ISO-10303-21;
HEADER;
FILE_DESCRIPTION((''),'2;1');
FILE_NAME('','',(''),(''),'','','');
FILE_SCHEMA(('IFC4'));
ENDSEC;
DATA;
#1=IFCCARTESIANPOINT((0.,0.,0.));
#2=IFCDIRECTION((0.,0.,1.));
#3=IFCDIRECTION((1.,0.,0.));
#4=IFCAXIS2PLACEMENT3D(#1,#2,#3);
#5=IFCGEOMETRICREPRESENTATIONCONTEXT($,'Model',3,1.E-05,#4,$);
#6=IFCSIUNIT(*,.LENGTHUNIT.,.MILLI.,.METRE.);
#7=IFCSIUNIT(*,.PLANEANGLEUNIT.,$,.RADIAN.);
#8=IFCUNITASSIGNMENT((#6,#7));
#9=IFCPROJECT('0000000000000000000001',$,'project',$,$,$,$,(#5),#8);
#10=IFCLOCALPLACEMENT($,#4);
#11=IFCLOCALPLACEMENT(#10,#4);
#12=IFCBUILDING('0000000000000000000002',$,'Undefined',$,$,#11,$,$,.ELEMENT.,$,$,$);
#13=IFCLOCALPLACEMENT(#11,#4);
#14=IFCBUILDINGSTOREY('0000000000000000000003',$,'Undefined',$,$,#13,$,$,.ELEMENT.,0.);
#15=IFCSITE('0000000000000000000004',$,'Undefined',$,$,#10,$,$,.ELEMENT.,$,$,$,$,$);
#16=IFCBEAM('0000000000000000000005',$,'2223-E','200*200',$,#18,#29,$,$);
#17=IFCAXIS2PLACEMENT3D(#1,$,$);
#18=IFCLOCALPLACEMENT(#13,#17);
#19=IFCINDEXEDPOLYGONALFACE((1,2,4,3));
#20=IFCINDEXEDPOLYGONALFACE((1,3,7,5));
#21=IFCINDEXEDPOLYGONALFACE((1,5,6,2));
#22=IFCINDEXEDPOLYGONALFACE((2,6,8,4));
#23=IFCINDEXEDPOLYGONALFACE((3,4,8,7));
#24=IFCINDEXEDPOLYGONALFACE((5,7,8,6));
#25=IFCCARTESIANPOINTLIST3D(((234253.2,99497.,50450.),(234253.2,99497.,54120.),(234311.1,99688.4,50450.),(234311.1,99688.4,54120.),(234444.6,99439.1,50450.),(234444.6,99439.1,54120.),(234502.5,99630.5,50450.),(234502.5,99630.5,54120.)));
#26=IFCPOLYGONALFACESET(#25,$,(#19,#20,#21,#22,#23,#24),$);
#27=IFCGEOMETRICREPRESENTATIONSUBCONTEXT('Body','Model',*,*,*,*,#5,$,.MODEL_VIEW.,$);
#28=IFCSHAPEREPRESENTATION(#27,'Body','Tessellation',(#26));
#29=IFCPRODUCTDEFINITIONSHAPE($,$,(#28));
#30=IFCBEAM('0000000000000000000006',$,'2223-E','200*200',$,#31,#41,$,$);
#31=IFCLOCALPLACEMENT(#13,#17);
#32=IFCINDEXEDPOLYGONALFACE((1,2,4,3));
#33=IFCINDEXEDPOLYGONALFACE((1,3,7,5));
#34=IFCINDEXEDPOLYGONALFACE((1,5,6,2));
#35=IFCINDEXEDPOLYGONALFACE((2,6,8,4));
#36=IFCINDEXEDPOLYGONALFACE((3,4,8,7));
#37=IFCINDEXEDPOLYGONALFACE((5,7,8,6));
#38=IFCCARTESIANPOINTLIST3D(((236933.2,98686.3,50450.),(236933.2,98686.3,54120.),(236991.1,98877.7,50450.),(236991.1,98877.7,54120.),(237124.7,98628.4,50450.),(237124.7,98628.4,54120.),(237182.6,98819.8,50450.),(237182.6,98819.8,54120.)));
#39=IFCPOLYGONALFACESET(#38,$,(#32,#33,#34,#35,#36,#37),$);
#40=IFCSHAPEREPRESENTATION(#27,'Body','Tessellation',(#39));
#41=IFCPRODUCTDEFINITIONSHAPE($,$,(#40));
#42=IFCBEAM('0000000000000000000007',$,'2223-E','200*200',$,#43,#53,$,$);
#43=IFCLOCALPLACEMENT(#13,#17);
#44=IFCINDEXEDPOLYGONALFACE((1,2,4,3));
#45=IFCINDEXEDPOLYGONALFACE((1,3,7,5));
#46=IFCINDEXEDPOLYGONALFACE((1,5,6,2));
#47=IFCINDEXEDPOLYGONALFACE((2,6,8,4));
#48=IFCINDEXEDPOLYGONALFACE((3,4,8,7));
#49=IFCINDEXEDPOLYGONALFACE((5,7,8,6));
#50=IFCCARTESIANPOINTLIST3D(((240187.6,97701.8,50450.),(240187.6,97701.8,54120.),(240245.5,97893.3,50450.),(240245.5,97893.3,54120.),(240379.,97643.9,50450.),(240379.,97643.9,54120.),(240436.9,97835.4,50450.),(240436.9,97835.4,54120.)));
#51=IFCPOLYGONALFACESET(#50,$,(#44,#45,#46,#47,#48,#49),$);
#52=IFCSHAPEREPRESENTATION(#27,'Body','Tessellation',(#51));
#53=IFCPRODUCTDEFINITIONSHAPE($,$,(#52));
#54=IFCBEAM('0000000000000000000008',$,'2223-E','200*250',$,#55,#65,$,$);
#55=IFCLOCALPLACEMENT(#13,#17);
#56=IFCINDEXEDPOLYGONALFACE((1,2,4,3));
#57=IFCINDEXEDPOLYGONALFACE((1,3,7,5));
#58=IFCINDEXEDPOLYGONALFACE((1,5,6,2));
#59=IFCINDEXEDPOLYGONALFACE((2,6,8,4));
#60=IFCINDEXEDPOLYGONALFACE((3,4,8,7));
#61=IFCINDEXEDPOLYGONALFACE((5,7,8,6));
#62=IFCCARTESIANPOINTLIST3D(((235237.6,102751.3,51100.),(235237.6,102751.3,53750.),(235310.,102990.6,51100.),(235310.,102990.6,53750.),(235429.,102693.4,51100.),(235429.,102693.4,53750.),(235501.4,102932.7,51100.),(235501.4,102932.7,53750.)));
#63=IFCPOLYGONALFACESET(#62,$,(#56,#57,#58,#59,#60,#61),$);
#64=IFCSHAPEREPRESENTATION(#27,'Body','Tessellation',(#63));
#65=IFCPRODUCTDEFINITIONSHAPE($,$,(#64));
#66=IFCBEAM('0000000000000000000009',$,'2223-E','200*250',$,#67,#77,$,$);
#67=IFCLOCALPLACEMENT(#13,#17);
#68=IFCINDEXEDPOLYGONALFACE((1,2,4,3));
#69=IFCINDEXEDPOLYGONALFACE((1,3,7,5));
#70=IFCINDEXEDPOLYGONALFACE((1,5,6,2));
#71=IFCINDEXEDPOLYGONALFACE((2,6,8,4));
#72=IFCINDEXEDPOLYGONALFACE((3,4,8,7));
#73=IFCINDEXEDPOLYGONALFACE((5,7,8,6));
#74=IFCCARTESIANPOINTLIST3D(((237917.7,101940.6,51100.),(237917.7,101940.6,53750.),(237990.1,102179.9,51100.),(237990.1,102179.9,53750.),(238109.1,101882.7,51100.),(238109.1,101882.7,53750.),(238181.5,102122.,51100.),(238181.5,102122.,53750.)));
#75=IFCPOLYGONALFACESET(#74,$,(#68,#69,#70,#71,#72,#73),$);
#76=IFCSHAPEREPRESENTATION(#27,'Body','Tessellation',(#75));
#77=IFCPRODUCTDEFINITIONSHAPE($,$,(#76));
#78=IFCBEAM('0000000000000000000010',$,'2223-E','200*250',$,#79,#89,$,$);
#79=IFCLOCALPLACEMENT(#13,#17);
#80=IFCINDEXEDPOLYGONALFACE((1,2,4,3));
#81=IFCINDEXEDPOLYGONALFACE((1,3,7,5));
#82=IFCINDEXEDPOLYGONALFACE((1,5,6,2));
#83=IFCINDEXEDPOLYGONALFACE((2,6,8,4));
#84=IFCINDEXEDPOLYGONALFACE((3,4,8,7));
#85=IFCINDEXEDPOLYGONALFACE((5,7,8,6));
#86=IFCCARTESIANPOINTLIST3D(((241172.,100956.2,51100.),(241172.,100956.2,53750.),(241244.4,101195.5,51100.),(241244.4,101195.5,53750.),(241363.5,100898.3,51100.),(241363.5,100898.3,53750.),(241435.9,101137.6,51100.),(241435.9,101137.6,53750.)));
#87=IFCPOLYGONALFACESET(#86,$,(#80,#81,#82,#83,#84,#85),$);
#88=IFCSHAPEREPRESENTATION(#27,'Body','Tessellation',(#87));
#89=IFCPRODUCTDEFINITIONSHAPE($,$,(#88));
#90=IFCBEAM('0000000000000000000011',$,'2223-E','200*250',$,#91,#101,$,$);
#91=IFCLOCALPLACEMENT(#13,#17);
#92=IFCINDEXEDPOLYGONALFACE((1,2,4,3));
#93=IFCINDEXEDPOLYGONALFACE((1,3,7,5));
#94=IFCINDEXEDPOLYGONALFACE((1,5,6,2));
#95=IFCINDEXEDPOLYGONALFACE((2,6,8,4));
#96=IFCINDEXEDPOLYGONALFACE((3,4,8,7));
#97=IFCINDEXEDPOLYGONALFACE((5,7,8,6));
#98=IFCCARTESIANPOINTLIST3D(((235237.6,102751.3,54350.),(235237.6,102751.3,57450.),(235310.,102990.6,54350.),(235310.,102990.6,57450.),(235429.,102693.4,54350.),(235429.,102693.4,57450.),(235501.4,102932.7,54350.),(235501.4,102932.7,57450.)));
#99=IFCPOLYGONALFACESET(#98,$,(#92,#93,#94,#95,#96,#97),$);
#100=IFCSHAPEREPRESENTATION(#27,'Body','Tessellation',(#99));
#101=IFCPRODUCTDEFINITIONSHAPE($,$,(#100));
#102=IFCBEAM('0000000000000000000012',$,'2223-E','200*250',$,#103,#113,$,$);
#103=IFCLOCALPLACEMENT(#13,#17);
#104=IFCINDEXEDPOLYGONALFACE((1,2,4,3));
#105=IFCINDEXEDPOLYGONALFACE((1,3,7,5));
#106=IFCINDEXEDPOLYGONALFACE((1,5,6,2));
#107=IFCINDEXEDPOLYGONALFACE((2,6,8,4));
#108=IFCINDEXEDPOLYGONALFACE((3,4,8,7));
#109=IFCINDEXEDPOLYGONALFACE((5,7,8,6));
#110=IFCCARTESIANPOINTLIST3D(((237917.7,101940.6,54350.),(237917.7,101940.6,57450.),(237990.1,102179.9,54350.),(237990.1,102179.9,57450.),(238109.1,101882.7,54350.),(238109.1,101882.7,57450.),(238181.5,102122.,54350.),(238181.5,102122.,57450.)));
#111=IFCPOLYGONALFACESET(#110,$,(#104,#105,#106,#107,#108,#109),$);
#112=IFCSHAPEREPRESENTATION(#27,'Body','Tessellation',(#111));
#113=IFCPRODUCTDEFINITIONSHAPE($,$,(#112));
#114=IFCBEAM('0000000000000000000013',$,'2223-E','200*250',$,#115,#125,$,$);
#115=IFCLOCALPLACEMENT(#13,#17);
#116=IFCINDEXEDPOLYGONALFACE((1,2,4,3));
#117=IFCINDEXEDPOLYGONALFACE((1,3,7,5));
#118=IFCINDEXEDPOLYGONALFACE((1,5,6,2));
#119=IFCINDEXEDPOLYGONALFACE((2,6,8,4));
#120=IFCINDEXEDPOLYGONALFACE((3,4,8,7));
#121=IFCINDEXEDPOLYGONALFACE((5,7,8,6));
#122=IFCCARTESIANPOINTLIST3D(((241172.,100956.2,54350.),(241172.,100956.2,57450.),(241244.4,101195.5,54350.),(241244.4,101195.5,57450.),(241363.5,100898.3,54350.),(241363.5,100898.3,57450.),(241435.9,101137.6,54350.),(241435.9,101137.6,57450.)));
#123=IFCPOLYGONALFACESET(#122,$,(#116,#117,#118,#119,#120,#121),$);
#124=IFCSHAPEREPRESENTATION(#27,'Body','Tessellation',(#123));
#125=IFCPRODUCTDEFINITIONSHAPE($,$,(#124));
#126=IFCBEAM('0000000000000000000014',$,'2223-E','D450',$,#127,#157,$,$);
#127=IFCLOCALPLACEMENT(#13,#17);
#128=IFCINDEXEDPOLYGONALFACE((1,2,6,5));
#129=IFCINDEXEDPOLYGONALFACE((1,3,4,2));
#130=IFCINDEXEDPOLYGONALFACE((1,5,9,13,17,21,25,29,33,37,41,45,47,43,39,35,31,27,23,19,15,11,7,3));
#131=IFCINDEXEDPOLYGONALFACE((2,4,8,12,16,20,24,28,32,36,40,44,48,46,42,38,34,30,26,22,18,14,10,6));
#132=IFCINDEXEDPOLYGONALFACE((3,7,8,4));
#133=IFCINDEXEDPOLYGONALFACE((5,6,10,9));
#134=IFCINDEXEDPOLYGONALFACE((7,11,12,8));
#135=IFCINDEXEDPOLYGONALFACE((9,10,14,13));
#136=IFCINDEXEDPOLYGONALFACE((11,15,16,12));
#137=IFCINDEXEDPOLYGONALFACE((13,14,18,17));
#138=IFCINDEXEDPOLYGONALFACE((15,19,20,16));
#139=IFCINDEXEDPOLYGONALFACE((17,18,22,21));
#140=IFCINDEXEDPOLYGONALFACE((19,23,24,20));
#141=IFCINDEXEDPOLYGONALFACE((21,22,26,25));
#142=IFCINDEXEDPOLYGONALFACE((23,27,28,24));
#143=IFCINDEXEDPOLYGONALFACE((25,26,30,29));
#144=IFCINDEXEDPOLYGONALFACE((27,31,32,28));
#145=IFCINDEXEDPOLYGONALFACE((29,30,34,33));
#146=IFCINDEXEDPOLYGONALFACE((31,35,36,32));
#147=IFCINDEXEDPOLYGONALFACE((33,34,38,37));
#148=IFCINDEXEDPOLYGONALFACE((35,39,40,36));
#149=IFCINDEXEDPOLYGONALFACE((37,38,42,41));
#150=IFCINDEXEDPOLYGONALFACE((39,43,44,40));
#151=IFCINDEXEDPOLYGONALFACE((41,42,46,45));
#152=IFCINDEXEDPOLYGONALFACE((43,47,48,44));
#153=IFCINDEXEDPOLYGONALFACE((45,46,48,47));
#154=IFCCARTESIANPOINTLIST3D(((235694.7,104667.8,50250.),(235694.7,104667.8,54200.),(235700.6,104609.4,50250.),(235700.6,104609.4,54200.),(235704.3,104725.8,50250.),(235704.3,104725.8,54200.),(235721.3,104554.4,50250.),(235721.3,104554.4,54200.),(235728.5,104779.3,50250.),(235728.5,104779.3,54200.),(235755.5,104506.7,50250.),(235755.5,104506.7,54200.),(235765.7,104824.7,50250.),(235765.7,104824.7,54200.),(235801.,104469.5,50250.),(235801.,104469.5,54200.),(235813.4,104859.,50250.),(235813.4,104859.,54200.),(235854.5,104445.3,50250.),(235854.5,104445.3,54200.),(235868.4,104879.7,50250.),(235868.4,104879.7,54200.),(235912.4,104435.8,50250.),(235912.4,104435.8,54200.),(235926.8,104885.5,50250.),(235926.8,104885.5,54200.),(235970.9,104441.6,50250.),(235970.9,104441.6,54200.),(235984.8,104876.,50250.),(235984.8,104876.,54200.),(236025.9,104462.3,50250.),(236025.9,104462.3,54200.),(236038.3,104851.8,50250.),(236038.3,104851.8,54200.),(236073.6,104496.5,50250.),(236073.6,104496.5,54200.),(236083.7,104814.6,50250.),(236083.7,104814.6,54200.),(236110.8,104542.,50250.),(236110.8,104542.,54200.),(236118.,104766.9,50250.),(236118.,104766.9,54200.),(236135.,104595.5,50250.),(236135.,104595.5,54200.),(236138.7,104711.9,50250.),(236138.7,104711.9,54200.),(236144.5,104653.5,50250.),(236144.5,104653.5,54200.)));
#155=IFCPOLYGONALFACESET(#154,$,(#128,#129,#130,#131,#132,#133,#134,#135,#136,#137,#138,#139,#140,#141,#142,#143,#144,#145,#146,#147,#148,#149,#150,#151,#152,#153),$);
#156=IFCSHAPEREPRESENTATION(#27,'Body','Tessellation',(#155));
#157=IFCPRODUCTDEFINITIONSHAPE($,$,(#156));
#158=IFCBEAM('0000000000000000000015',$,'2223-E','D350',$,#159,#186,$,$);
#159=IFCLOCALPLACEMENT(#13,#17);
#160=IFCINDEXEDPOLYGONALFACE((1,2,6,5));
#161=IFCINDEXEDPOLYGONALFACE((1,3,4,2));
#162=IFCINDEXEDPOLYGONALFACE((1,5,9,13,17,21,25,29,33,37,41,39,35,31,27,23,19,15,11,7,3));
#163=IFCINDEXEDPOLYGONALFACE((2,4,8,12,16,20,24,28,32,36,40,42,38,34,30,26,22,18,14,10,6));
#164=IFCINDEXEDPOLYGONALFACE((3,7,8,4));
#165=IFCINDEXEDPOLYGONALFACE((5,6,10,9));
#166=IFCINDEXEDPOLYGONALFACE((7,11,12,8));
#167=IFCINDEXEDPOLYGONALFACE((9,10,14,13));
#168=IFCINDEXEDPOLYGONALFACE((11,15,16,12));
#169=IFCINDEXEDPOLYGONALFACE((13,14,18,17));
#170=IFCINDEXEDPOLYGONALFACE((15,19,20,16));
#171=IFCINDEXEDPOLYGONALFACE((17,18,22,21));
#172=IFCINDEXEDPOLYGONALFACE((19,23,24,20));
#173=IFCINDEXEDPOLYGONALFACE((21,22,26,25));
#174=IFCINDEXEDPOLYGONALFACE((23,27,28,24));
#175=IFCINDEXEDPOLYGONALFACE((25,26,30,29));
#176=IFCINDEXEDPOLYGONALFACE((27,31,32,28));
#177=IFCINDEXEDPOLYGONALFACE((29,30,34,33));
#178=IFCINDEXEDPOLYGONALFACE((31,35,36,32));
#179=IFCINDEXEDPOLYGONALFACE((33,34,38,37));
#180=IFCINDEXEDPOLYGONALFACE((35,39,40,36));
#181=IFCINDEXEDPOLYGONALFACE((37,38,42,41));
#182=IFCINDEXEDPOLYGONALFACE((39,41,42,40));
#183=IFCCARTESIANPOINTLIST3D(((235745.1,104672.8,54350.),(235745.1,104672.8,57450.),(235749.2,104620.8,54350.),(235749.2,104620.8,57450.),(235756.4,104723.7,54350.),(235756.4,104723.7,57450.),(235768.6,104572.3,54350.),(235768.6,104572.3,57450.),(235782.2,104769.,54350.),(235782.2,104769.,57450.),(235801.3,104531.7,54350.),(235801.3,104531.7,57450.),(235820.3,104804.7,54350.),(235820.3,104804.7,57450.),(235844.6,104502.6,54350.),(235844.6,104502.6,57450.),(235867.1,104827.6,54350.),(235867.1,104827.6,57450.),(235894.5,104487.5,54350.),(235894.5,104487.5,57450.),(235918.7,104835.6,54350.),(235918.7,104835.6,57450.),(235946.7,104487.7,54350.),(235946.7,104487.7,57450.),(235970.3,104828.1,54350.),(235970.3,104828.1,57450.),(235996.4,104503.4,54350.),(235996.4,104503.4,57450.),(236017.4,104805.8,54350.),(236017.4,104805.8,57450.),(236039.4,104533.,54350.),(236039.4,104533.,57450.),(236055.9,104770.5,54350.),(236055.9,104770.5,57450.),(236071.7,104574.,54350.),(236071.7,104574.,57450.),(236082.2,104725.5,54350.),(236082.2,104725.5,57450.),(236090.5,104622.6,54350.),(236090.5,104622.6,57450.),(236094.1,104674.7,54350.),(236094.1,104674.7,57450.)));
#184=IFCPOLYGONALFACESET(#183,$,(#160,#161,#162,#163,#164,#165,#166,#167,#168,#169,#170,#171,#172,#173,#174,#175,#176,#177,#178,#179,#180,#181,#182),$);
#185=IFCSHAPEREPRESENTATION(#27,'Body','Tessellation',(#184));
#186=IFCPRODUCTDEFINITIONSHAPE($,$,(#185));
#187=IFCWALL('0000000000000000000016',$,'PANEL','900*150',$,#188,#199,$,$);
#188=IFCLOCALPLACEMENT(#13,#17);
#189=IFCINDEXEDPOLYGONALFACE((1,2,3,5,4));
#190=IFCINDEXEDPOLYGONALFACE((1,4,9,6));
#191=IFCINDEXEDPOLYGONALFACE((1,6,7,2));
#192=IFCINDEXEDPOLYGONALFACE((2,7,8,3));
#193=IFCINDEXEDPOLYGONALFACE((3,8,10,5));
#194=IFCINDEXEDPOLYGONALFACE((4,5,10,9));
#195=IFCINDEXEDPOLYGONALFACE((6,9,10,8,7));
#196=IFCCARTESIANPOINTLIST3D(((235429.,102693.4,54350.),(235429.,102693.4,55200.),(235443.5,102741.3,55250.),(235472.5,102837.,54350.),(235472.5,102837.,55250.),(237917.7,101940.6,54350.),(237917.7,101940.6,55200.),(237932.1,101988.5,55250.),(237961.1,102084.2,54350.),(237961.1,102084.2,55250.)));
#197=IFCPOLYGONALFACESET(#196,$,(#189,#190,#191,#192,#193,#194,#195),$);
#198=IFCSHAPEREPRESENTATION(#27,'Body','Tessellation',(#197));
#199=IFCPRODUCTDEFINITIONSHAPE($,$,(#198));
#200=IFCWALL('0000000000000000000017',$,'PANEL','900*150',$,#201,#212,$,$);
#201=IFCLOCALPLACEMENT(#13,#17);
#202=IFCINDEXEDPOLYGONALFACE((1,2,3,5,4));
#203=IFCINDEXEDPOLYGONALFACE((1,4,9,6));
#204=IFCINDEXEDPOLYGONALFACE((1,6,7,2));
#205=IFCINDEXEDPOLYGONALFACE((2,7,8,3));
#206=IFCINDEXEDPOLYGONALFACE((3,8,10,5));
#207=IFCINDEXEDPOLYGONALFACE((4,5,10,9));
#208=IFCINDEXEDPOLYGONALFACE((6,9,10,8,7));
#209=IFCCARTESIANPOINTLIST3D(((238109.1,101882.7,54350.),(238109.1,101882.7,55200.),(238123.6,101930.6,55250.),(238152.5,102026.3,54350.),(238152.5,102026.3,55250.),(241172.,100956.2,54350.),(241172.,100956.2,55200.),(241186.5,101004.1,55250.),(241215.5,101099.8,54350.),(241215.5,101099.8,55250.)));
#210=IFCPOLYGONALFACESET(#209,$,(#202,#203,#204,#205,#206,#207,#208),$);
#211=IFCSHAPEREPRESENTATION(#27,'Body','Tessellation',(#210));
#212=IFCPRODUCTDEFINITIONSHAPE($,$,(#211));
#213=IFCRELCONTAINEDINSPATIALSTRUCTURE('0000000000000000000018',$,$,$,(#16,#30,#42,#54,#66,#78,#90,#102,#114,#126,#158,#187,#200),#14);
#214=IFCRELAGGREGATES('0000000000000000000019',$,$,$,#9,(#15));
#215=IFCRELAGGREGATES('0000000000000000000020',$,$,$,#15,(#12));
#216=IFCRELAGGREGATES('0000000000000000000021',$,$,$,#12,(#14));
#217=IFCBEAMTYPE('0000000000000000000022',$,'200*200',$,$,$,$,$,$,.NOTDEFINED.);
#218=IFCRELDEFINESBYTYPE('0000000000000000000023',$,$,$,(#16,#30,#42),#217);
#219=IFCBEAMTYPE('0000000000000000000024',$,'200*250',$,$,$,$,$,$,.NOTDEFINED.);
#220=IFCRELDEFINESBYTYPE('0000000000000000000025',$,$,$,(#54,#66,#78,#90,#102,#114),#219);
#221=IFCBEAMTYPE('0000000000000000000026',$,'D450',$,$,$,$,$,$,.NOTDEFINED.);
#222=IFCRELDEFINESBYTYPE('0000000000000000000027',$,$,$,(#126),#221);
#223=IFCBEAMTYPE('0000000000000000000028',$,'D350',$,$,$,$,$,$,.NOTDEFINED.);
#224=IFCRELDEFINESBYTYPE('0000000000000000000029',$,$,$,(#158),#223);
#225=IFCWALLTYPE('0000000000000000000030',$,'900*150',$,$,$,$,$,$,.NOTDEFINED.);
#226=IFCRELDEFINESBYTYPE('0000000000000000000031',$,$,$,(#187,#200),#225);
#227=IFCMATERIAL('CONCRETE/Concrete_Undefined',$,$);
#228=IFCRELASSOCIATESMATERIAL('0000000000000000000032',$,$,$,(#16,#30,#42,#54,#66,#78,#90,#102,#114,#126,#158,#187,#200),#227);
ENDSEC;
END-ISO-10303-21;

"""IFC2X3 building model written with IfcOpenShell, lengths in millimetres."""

from ifc_helpers import new_model, si_unit, frame, frame_2d, origin_with_axes, origin_2d_with_axis, place, context, subcontext, project, spatial, rectangle, circle, extrude, clip, halfspace, material, type_object, element, save


model = new_model("IFC2X3")

# Units and contexts
model_context = context("Model", 3, precision=1e-05, world=origin_with_axes())
body_context = subcontext(model_context, "Body", "Model", "MODEL_VIEW")
ifc_project = project(units=[si_unit("LENGTHUNIT", "METRE", prefix="MILLI"), si_unit("PLANEANGLEUNIT", "RADIAN")], contexts=[model_context])

# Site, building, storey
site_placement = place(None, origin_with_axes())
site = spatial("IfcSite", under=ifc_project, at=site_placement, Name="Undefined", CompositionType="ELEMENT")
building_placement = place(site_placement, origin_with_axes())
building = spatial("IfcBuilding", under=site, at=building_placement, Name="Undefined", CompositionType="ELEMENT")
storey_placement = place(building_placement, origin_with_axes())
storey = spatial("IfcBuildingStorey", under=building, at=storey_placement, Name="Undefined", CompositionType="ELEMENT", Elevation=0.0)

# Shared definitions
ifc_material_1 = material(Name="CONCRETE/Concrete_Undefined")

# Beams
beam_type_1 = type_object("IfcBeamType", Name="200*200", PredefinedType="NOTDEFINED")
for number, where, z_axis, x_axis, name in (
    (1, (234377.8, 99563.7, 50450.0), (0.957167, -0.289538, 0.0), (0.0, 0.0, 1.0), "2223-E"),
    (2, (237057.9, 98753.0, 50450.0), (0.957167, -0.289538, 0.0), (0.0, 0.0, 1.0), "2223-E"),
    (3, (240312.3, 97768.6, 50450.0), (0.957167, -0.289538, 0.0), (0.0, 0.0, 1.0), "2223-E"),
):
    element("IfcBeam", number, at=place(storey_placement, frame(where, z_axis=z_axis, x_axis=x_axis)), inside=storey, type_object=beam_type_1, material=ifc_material_1, Name=name, Description="200*200", context=body_context, shape_type="SweptSolid", body=[
        extrude(rectangle(XDim=200.0, YDim=200.0, at=origin_2d_with_axis()), frame((3670.0, 0.0, 0.0), z_axis=(-1.0, 0.0, 0.0), x_axis=(0.0, -1.0, 0.0)), (0.0, 0.0, 1.0), 3670.0),
    ])
beam_type_2 = type_object("IfcBeamType", Name="200*250", PredefinedType="NOTDEFINED")
for number, where, z_axis, x_axis, name in (
    (4, (235369.5, 102842.0, 51100.0), (0.957167, -0.289538, 0.0), (0.0, 0.0, 1.0), "2223-E"),
    (5, (238049.6, 102031.3, 51100.0), (0.957167, -0.289538, 0.0), (0.0, 0.0, 1.0), "2223-E"),
    (6, (241303.9, 101046.9, 51100.0), (0.957167, -0.289538, 0.0), (0.0, 0.0, 1.0), "2223-E"),
):
    element("IfcBeam", number, at=place(storey_placement, frame(where, z_axis=z_axis, x_axis=x_axis)), inside=storey, type_object=beam_type_2, material=ifc_material_1, Name=name, Description="200*250", context=body_context, shape_type="SweptSolid", body=[
        extrude(rectangle(XDim=250.0, YDim=200.0, at=origin_2d_with_axis()), frame((2650.0, 0.0, 0.0), z_axis=(-1.0, 0.0, 0.0), x_axis=(0.0, -1.0, 0.0)), (0.0, 0.0, 1.0), 2650.0),
    ])
for number, where, z_axis, x_axis, name in (
    (7, (235369.5, 102842.0, 54350.0), (0.957167, -0.289538, 0.0), (0.0, 0.0, 1.0), "2223-E"),
    (8, (238049.6, 102031.3, 54350.0), (0.957167, -0.289538, 0.0), (0.0, 0.0, 1.0), "2223-E"),
    (9, (241303.9, 101046.9, 54350.0), (0.957167, -0.289538, 0.0), (0.0, 0.0, 1.0), "2223-E"),
):
    element("IfcBeam", number, at=place(storey_placement, frame(where, z_axis=z_axis, x_axis=x_axis)), inside=storey, type_object=beam_type_2, material=ifc_material_1, Name=name, Description="200*250", context=body_context, shape_type="SweptSolid", body=[
        extrude(rectangle(XDim=250.0, YDim=200.0, at=origin_2d_with_axis()), frame((3100.0, 0.0, 0.0), z_axis=(-1.0, 0.0, 0.0), x_axis=(0.0, -1.0, 0.0)), (0.0, 0.0, 1.0), 3100.0),
    ])
beam_type_3 = type_object("IfcBeamType", Name="D450", PredefinedType="NOTDEFINED")
beam_1_placement = place(storey_placement, frame((235919.6, 104660.6, 50250.0), z_axis=(0.957167, -0.289538, 0.0), x_axis=(0.0, 0.0, 1.0)))
element("IfcBeam", 10, at=beam_1_placement, inside=storey, type_object=beam_type_3, material=ifc_material_1, Name="2223-E", Description="D450", context=body_context, shape_type="SweptSolid", body=[
    extrude(circle(Radius=225.0, at=origin_2d_with_axis()), frame((3950.0, 0.0, 0.0), z_axis=(-1.0, 0.0, 0.0), x_axis=(0.0, -1.0, 0.0)), (0.0, 0.0, 1.0), 3950.0),
])
beam_type_4 = type_object("IfcBeamType", Name="D350", PredefinedType="NOTDEFINED")
beam_2_placement = place(storey_placement, frame((235919.6, 104660.6, 54350.0), z_axis=(0.957167, -0.289538, 0.0), x_axis=(0.0, 0.0, 1.0)))
element("IfcBeam", 11, at=beam_2_placement, inside=storey, type_object=beam_type_4, material=ifc_material_1, Name="2223-E", Description="D350", context=body_context, shape_type="SweptSolid", body=[
    extrude(circle(Radius=175.0, at=origin_2d_with_axis()), frame((3100.0, 0.0, 0.0), z_axis=(-1.0, 0.0, 0.0), x_axis=(0.0, -1.0, 0.0)), (0.0, 0.0, 1.0), 3100.0),
])

# Walls
wall_type_1 = type_object("IfcWallType", Name="900*150", PredefinedType="NOTDEFINED")
wall_1_placement = place(storey_placement, frame((235450.7, 102765.2, 54350.0), z_axis=(0.0, 0.0, 1.0), x_axis=(0.957166, -0.289539, 0.0)))
element("IfcWall", 12, at=wall_1_placement, inside=storey, type_object=wall_type_1, material=ifc_material_1, Name="PANEL", Description="900*150", context=body_context, shape_type="Clipping", body=[
    clip(extrude(rectangle(XDim=2600.0, YDim=150.0, at=frame_2d((0.0, 1300.0), x_axis=(0.0, -1.0))), frame((0.0, 0.0, 0.0), z_axis=(0.0, 0.0, 1.0), x_axis=(0.0, -1.0, 0.0)), (0.0, 0.0, 1.0), 900.0), halfspace(frame((2600.0, 75.0, 1000.0), z_axis=(0.000001, -0.707072, 0.707141), x_axis=(0.0, -0.707141, -0.707072)), False)),
])
wall_2_placement = place(storey_placement, frame((238130.8, 101954.5, 54350.0), z_axis=(0.0, 0.0, 1.0), x_axis=(0.957166, -0.289539, 0.0)))
element("IfcWall", 13, at=wall_2_placement, inside=storey, type_object=wall_type_1, material=ifc_material_1, Name="PANEL", Description="900*150", context=body_context, shape_type="Clipping", body=[
    clip(extrude(rectangle(XDim=3200.0, YDim=150.0, at=frame_2d((0.0, 1600.0), x_axis=(0.0, -1.0))), frame((0.0, 0.0, 0.0), z_axis=(0.0, 0.0, 1.0), x_axis=(0.0, -1.0, 0.0)), (0.0, 0.0, 1.0), 900.0), halfspace(frame((3200.0, 75.0, 1000.0), z_axis=(0.000001, -0.707072, 0.707141), x_axis=(0.0, -0.707141, -0.707072)), False)),
])

save(model, "model.ifc")
